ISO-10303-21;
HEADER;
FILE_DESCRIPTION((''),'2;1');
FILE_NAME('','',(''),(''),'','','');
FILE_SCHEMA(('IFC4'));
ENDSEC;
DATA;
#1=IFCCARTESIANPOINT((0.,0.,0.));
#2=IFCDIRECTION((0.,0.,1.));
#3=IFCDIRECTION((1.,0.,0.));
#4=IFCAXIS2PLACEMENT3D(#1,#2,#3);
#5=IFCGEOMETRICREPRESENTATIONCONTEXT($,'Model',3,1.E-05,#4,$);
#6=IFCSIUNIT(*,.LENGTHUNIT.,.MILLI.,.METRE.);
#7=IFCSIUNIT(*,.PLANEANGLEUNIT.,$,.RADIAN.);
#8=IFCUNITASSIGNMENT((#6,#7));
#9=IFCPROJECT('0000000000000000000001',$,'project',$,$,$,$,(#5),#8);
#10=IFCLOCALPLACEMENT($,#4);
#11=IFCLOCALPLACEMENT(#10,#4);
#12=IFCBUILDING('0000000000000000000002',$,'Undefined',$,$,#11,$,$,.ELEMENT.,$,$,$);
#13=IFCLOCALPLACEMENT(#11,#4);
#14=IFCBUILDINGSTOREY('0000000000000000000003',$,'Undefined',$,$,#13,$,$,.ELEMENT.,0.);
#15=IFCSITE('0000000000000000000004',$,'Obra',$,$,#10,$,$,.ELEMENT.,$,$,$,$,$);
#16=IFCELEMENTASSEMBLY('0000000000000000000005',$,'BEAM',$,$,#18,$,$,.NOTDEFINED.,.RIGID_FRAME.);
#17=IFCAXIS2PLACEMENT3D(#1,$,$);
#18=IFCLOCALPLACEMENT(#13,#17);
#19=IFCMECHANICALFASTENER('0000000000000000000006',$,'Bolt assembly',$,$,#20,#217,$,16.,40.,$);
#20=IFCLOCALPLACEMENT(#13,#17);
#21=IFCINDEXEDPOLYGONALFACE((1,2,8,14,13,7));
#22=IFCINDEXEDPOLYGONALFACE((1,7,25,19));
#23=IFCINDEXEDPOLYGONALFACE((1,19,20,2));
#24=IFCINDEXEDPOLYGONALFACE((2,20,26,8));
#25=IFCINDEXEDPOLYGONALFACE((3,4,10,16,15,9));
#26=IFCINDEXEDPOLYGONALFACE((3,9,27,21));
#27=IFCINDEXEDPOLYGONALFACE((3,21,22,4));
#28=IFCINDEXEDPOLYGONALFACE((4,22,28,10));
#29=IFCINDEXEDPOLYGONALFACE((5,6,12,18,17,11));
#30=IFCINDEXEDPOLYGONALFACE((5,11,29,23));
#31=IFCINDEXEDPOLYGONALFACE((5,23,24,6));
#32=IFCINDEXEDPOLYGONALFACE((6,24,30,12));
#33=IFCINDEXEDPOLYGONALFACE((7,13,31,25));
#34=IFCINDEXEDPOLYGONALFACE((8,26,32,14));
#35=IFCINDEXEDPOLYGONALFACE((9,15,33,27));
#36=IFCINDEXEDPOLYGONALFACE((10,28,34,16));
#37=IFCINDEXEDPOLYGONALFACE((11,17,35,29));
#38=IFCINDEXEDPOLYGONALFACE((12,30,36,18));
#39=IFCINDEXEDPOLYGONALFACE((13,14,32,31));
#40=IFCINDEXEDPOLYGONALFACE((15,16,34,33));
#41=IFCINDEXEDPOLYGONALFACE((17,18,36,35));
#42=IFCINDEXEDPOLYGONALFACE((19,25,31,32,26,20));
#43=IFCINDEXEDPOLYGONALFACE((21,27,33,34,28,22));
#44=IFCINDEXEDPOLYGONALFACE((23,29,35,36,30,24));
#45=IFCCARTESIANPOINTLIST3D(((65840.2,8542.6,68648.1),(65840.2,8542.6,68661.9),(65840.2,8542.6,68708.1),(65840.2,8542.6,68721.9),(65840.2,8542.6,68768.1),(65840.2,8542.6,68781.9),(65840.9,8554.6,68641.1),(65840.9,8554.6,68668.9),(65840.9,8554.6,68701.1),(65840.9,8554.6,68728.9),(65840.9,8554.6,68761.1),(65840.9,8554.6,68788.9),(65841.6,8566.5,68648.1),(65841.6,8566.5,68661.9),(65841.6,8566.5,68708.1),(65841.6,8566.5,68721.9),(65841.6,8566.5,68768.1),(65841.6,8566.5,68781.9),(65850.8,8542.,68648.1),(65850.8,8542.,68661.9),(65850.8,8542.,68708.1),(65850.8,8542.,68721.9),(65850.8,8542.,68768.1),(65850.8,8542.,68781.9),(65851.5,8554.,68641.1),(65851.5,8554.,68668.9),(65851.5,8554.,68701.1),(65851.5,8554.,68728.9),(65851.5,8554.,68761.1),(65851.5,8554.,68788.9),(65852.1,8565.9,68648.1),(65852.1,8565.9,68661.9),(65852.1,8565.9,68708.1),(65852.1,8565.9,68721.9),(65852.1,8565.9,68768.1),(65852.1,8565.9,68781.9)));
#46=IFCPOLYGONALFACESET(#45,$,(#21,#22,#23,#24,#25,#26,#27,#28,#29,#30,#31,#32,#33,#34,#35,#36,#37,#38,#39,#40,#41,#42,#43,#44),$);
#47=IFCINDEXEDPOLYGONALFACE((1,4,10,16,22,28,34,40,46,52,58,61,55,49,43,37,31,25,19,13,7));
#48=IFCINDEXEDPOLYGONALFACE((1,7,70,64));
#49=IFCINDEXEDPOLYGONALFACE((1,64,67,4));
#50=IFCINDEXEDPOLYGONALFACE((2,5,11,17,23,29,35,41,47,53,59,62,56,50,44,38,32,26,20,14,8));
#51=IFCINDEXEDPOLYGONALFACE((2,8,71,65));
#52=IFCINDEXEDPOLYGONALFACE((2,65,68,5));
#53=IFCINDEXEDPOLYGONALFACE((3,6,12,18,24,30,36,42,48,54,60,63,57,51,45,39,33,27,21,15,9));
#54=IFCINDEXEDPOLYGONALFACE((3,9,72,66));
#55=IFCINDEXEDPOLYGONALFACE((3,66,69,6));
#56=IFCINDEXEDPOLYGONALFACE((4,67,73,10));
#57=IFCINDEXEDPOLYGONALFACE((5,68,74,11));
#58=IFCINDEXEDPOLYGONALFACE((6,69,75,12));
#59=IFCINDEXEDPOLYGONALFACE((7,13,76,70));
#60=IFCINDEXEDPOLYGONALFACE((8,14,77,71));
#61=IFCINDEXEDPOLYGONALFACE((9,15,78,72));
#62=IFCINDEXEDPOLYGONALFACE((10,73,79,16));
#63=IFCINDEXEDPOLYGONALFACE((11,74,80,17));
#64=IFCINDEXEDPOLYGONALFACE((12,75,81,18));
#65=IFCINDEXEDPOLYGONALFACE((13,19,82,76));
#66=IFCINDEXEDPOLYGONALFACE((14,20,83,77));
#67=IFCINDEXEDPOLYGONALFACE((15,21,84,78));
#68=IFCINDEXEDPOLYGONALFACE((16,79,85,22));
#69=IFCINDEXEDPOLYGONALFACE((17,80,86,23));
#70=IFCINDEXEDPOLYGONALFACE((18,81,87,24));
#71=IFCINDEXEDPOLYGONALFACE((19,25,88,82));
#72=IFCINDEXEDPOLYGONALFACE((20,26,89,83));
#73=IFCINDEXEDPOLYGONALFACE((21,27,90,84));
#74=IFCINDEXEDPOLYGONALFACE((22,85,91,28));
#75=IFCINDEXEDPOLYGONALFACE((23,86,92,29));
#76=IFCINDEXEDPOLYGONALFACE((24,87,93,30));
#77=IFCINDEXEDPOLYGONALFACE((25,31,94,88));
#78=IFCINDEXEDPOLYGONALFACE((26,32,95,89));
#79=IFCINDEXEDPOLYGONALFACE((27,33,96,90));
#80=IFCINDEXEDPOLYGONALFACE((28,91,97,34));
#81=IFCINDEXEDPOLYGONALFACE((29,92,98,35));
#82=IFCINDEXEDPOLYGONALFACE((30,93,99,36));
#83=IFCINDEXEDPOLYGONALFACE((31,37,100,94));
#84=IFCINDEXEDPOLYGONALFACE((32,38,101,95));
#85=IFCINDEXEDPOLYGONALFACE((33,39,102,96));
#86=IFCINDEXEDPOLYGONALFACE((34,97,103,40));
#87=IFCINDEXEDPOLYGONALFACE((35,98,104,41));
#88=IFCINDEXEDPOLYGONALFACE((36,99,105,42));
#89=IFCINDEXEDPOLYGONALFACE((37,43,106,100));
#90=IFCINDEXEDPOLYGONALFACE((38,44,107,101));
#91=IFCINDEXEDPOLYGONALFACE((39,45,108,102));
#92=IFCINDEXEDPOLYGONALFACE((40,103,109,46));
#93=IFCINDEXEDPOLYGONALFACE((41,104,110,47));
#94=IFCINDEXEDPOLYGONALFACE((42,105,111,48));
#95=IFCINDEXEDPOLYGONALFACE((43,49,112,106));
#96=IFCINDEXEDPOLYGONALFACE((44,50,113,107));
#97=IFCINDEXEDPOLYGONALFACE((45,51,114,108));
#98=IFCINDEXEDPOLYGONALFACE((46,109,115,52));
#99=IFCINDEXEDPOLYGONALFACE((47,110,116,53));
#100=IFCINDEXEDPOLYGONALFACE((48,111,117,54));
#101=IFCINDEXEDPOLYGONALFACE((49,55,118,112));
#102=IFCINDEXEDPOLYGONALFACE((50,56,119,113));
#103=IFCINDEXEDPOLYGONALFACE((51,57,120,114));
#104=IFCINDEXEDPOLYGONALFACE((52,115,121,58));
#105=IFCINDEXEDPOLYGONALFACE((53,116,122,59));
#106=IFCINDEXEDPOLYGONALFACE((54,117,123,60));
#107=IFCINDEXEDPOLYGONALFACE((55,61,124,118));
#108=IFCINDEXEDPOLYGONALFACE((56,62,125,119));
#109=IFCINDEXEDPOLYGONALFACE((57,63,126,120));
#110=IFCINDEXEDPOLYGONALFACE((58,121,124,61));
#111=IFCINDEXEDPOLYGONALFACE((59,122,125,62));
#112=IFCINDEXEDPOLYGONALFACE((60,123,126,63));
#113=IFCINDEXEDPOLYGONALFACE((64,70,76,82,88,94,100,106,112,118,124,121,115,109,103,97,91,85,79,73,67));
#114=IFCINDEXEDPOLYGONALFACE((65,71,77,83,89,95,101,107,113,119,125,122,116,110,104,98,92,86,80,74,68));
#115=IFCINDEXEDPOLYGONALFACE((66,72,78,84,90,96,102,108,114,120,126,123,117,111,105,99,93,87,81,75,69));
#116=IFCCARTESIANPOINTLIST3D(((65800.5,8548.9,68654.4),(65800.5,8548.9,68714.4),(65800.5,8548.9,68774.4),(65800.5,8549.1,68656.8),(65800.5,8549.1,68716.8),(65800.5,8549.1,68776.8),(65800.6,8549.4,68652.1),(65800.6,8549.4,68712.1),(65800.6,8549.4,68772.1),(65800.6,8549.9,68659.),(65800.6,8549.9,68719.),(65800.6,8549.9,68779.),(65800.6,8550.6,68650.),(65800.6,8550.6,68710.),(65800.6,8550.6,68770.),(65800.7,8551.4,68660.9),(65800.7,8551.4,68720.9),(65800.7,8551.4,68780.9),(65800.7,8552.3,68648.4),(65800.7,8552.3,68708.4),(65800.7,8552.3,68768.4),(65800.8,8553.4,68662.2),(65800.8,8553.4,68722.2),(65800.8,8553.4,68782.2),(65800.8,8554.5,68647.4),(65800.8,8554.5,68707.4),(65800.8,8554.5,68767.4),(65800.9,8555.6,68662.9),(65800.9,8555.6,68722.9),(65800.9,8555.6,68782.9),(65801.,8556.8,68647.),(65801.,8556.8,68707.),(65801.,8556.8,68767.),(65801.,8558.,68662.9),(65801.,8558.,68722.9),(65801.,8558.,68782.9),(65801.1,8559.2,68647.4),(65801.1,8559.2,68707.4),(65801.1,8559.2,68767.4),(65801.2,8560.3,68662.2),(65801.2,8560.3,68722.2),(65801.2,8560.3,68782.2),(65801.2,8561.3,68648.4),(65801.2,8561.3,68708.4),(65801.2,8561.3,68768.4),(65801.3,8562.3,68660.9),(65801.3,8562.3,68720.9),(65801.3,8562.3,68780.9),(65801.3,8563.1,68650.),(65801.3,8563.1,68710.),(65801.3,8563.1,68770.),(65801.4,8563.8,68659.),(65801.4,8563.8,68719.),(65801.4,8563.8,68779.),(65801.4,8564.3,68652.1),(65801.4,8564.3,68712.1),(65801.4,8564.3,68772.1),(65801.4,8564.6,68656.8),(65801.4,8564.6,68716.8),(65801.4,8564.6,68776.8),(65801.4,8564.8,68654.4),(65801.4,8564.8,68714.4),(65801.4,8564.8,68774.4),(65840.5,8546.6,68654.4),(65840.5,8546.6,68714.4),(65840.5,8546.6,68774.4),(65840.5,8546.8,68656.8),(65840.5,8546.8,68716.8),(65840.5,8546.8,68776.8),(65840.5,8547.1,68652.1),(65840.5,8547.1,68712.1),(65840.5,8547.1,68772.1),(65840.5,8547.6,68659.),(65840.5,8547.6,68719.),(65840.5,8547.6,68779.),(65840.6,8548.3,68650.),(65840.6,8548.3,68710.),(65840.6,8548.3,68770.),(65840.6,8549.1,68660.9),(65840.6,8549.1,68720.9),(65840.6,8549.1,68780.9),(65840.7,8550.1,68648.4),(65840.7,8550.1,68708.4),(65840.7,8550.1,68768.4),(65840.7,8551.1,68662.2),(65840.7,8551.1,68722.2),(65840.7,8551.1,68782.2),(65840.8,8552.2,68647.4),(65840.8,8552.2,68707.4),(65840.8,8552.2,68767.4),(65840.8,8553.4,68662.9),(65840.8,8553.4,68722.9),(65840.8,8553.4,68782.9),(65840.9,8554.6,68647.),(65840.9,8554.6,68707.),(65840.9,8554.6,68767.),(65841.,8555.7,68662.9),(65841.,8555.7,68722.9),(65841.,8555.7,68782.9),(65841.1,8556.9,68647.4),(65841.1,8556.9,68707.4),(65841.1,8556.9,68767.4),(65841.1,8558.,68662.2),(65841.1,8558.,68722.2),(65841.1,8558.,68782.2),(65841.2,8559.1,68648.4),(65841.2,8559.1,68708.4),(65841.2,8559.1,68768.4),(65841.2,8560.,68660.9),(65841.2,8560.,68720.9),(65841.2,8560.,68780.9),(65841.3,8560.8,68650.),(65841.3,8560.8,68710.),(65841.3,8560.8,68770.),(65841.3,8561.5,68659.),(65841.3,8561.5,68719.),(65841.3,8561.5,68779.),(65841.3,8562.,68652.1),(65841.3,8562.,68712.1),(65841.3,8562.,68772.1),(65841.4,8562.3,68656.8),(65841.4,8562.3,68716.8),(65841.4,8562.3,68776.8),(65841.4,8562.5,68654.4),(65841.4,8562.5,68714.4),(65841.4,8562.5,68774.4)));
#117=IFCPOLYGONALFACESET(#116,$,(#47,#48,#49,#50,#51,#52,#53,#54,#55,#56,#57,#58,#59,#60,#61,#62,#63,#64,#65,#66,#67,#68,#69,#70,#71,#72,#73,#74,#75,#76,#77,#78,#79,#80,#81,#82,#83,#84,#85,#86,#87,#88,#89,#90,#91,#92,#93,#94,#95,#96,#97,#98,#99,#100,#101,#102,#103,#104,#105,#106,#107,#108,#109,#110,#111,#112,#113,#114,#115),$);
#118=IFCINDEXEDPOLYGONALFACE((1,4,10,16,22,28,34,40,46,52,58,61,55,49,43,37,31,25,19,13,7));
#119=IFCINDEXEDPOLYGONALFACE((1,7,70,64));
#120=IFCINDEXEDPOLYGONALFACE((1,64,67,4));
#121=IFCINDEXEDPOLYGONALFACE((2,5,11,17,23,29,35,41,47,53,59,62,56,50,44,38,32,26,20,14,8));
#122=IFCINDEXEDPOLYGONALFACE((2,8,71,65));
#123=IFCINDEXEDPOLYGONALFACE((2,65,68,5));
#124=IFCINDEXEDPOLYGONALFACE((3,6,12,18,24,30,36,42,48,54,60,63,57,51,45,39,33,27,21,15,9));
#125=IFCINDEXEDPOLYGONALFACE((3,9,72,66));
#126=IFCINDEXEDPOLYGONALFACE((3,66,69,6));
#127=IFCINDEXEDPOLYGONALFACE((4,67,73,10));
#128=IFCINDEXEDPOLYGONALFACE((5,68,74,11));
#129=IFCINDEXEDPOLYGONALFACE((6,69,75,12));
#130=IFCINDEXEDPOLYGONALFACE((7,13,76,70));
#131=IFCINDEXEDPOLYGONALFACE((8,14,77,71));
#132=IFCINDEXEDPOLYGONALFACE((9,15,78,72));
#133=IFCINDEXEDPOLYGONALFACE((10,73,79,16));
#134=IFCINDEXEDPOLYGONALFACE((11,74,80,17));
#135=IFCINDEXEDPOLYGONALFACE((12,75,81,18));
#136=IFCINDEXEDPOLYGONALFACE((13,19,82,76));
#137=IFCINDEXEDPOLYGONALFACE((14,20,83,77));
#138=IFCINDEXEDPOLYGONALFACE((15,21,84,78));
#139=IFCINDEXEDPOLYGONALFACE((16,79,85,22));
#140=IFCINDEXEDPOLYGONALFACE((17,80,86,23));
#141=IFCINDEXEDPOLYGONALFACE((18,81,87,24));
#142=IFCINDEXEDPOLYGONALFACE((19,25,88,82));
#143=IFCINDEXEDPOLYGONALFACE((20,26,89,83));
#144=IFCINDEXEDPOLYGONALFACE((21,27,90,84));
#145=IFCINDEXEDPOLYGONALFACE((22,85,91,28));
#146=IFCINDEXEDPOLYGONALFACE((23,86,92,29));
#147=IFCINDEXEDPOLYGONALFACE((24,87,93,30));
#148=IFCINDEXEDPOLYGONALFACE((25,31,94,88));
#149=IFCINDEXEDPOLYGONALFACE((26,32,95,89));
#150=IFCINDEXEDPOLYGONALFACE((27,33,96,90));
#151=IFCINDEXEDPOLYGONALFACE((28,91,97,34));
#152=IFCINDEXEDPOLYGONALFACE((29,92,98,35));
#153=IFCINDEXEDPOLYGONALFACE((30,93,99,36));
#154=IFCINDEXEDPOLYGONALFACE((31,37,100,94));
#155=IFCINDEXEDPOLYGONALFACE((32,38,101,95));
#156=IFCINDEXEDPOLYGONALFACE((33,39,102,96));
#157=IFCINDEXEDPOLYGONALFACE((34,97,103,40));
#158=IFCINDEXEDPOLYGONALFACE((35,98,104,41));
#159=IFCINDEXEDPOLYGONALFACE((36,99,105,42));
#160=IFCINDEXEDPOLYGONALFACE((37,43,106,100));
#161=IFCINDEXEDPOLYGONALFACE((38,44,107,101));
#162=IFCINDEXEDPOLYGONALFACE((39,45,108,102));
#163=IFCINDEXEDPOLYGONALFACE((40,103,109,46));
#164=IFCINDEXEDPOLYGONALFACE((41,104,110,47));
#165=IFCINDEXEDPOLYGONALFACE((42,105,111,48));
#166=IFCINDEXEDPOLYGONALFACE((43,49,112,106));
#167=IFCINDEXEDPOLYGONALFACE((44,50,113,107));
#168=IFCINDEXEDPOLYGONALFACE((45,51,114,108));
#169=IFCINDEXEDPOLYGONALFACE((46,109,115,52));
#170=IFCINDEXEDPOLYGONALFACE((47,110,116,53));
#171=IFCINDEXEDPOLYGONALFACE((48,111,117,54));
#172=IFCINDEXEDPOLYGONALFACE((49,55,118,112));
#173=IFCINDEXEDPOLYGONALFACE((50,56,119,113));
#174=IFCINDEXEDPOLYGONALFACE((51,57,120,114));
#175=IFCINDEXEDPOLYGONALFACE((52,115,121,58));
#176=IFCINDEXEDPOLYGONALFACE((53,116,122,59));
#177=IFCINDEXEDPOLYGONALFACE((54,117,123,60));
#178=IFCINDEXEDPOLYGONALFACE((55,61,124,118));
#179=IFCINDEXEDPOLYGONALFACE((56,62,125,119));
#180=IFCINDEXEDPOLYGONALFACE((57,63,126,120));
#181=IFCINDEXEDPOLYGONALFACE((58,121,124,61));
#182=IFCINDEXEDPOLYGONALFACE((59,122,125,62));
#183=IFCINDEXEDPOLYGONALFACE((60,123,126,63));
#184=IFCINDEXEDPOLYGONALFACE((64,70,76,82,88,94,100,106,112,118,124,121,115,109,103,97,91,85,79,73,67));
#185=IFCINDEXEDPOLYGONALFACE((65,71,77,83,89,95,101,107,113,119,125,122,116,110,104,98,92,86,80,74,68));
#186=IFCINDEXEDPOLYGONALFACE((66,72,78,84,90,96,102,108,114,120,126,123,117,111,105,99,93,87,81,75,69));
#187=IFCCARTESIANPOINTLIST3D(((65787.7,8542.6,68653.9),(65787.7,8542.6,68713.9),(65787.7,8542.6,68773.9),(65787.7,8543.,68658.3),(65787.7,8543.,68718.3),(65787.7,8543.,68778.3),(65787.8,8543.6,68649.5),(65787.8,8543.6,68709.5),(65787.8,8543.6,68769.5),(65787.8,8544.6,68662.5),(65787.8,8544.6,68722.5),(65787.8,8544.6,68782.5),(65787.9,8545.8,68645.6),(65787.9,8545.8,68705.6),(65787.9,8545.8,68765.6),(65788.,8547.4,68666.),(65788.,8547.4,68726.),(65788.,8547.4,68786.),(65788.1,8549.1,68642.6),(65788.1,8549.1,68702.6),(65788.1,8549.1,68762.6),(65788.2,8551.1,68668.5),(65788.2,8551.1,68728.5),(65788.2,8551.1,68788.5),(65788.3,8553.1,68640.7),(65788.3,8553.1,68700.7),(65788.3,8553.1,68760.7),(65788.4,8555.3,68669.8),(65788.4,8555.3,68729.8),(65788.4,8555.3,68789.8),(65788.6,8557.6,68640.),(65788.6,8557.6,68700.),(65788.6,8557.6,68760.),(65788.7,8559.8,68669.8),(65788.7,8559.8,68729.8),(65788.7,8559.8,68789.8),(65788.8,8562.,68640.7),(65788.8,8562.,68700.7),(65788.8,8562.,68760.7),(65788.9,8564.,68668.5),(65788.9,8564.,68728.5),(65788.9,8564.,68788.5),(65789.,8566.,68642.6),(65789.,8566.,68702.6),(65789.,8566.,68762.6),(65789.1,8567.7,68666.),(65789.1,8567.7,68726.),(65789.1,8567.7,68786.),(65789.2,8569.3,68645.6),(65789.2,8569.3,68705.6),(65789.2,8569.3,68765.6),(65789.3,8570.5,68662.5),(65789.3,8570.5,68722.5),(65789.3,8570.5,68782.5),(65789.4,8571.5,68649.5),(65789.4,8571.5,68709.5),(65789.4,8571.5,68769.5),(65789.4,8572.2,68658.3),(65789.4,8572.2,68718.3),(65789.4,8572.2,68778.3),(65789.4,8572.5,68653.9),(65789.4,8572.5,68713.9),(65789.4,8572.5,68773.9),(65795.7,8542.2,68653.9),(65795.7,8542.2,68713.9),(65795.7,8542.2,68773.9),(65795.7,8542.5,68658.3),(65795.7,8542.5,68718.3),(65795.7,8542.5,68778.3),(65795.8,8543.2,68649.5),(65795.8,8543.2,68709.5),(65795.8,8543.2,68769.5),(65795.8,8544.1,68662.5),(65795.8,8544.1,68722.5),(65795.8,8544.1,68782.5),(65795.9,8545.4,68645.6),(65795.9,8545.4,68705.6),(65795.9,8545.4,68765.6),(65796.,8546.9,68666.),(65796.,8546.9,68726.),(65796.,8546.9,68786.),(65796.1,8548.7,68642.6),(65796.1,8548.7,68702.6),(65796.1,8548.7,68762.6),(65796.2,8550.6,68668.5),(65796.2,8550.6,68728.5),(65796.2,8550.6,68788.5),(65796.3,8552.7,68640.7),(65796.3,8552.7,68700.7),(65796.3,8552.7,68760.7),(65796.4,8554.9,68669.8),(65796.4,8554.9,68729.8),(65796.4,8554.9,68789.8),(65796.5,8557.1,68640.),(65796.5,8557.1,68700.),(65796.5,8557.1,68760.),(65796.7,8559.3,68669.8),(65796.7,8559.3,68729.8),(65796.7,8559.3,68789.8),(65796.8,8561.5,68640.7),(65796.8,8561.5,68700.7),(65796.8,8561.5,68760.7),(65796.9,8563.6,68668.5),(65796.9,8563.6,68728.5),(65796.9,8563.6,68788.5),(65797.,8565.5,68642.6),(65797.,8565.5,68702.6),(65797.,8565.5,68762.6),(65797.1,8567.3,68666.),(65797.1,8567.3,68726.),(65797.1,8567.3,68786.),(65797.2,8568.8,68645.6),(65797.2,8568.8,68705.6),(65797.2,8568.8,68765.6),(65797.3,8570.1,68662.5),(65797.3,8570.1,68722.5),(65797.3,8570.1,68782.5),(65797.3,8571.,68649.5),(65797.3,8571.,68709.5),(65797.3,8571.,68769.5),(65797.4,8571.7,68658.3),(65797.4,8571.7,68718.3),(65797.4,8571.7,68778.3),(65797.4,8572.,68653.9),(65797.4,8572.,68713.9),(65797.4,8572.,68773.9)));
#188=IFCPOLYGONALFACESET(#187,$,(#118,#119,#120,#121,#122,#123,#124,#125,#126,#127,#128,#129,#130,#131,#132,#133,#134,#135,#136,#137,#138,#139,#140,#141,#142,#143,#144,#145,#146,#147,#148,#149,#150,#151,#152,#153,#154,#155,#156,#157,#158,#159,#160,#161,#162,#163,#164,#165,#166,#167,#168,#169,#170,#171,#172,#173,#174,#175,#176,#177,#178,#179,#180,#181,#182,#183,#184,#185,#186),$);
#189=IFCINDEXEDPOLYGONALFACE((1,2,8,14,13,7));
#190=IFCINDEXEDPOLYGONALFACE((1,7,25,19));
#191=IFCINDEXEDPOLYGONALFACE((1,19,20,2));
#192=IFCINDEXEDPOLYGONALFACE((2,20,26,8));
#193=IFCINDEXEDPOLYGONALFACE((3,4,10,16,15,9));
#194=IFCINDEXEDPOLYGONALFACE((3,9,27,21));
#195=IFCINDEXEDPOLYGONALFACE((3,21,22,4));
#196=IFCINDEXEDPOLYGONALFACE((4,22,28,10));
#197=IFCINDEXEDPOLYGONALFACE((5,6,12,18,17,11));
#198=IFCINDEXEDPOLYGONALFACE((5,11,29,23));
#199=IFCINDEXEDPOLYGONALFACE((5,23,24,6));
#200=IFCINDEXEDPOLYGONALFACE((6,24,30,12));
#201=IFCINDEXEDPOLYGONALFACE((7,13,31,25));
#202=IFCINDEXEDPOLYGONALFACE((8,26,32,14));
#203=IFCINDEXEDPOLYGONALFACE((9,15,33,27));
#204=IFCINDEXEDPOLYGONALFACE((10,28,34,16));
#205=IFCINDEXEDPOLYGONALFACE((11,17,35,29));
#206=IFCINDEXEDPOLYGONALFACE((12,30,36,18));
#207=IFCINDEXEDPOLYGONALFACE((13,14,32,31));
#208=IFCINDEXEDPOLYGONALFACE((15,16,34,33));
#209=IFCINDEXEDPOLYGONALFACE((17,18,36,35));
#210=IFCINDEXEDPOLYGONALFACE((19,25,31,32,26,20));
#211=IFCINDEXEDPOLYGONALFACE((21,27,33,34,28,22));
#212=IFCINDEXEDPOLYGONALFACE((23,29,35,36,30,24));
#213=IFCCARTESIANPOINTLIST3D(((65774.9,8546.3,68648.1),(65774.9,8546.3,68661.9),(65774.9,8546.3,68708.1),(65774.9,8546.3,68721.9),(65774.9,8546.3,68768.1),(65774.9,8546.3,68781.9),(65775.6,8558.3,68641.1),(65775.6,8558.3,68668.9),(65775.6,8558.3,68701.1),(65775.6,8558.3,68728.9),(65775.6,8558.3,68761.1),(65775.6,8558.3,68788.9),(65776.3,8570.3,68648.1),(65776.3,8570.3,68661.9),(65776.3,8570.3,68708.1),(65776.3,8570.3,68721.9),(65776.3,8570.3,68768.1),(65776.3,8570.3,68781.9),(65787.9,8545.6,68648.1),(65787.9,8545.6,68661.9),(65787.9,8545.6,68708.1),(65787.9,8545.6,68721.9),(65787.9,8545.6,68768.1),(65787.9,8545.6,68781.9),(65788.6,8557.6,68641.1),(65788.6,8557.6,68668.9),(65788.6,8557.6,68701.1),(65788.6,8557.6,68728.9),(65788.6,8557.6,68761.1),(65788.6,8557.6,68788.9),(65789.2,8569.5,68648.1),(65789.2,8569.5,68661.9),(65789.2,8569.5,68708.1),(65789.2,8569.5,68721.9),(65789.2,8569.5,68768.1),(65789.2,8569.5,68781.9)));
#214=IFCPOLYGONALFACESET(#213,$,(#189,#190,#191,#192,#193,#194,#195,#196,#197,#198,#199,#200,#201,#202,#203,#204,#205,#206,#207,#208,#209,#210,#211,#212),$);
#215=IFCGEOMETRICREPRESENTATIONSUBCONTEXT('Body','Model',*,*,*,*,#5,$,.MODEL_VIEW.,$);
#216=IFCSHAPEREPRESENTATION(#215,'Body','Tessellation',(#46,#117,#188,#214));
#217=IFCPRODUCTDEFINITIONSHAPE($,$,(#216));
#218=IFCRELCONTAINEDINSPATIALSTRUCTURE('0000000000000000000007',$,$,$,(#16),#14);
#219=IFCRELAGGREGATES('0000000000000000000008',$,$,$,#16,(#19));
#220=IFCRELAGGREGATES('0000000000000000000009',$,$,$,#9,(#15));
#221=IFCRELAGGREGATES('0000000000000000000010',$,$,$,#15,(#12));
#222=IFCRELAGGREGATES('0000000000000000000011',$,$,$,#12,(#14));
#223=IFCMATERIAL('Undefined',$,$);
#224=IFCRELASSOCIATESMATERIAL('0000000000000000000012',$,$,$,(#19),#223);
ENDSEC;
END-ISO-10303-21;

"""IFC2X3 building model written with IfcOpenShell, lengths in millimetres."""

from ifc_helpers import new_model, si_unit, frame, origin_with_axes, origin_2d_with_axis, place, context, subcontext, project, spatial, polyline, circle, outline, extrude, source, transform, mapped, material, element, aggregate, save


model = new_model("IFC2X3")

# Units and contexts
model_context = context("Model", 3, precision=1e-05, world=origin_with_axes())
body_context = subcontext(model_context, "Body", "Model", "MODEL_VIEW")
ifc_project = project(units=[si_unit("LENGTHUNIT", "METRE", prefix="MILLI"), si_unit("PLANEANGLEUNIT", "RADIAN")], contexts=[model_context])

# Site, building, storey
site_placement = place(None, origin_with_axes())
site = spatial("IfcSite", under=ifc_project, at=site_placement, Name="Obra", CompositionType="ELEMENT")
building_placement = place(site_placement, origin_with_axes())
building = spatial("IfcBuilding", under=site, at=building_placement, Name="Undefined", CompositionType="ELEMENT")
storey_placement = place(building_placement, origin_with_axes())
storey = spatial("IfcBuildingStorey", under=building, at=storey_placement, Name="Undefined", CompositionType="ELEMENT", Elevation=0.0)

# Element assembly, mechanical fastener
assembly_1_placement = place(storey_placement, origin_with_axes())
assembly_1 = element("IfcElementAssembly", 1, at=assembly_1_placement, inside=storey, Name="BEAM", AssemblyPlace="NOTDEFINED", PredefinedType="RIGID_FRAME")
ifc_material_1 = material(Name="Undefined")
shared_shape_1 = source(origin_with_axes(), body_context, "Body", "SweptSolid", [
    extrude(outline(polyline([(13.9, 0.0), (6.9, 12.0), (-6.9, 12.0), (-13.9, 0.0), (-6.9, -12.0), (6.9, -12.0), (13.9, 0.0)])), frame((0.0, -19.7, 0.0), z_axis=(0.0, 1.0, 0.0), x_axis=(1.0, 0.0, 0.0)), (0.0, 0.0, 1.0), 10.6),
    extrude(circle(Radius=8.0, at=origin_2d_with_axis()), frame((0.0, -9.1, 0.0), z_axis=(0.0, 1.0, 0.0), x_axis=(1.0, 0.0, 0.0)), (0.0, 0.0, 1.0), 40.0),
    extrude(circle(Radius=15.0, at=origin_2d_with_axis()), frame((0.0, 35.3, 0.0), z_axis=(0.0, 1.0, 0.0), x_axis=(1.0, 0.0, 0.0)), (0.0, 0.0, 1.0), 8.0),
    extrude(outline(polyline([(13.9, 0.0), (6.9, 12.0), (-6.9, 12.0), (-13.9, 0.0), (-6.9, -12.0), (6.9, -12.0), (13.9, 0.0)])), frame((0.0, 43.3, 0.0), z_axis=(0.0, 1.0, 0.0), x_axis=(1.0, 0.0, 0.0)), (0.0, 0.0, 1.0), 13.0),
])
mechanical_fastener_1_placement = place(assembly_1_placement, frame((65829.0, 8505.2, 68835.0), z_axis=(0.05711, 0.998368, 0.0), x_axis=(0.0, 0.0, -1.0)))
mechanical_fastener_1 = element("IfcMechanicalFastener", 2, at=mechanical_fastener_1_placement, material=ifc_material_1, Name="Bolt assembly", NominalDiameter=16.0, NominalLength=40.0, context=body_context, shape_type="MappedRepresentation", body=[
    mapped(shared_shape_1, transform((60.0, 0.0, 50.0))),
    mapped(shared_shape_1, transform((120.0, 0.0, 50.0))),
    mapped(shared_shape_1, transform((180.0, 0.0, 50.0))),
])
aggregate(assembly_1, [mechanical_fastener_1])

save(model, "model.ifc")
